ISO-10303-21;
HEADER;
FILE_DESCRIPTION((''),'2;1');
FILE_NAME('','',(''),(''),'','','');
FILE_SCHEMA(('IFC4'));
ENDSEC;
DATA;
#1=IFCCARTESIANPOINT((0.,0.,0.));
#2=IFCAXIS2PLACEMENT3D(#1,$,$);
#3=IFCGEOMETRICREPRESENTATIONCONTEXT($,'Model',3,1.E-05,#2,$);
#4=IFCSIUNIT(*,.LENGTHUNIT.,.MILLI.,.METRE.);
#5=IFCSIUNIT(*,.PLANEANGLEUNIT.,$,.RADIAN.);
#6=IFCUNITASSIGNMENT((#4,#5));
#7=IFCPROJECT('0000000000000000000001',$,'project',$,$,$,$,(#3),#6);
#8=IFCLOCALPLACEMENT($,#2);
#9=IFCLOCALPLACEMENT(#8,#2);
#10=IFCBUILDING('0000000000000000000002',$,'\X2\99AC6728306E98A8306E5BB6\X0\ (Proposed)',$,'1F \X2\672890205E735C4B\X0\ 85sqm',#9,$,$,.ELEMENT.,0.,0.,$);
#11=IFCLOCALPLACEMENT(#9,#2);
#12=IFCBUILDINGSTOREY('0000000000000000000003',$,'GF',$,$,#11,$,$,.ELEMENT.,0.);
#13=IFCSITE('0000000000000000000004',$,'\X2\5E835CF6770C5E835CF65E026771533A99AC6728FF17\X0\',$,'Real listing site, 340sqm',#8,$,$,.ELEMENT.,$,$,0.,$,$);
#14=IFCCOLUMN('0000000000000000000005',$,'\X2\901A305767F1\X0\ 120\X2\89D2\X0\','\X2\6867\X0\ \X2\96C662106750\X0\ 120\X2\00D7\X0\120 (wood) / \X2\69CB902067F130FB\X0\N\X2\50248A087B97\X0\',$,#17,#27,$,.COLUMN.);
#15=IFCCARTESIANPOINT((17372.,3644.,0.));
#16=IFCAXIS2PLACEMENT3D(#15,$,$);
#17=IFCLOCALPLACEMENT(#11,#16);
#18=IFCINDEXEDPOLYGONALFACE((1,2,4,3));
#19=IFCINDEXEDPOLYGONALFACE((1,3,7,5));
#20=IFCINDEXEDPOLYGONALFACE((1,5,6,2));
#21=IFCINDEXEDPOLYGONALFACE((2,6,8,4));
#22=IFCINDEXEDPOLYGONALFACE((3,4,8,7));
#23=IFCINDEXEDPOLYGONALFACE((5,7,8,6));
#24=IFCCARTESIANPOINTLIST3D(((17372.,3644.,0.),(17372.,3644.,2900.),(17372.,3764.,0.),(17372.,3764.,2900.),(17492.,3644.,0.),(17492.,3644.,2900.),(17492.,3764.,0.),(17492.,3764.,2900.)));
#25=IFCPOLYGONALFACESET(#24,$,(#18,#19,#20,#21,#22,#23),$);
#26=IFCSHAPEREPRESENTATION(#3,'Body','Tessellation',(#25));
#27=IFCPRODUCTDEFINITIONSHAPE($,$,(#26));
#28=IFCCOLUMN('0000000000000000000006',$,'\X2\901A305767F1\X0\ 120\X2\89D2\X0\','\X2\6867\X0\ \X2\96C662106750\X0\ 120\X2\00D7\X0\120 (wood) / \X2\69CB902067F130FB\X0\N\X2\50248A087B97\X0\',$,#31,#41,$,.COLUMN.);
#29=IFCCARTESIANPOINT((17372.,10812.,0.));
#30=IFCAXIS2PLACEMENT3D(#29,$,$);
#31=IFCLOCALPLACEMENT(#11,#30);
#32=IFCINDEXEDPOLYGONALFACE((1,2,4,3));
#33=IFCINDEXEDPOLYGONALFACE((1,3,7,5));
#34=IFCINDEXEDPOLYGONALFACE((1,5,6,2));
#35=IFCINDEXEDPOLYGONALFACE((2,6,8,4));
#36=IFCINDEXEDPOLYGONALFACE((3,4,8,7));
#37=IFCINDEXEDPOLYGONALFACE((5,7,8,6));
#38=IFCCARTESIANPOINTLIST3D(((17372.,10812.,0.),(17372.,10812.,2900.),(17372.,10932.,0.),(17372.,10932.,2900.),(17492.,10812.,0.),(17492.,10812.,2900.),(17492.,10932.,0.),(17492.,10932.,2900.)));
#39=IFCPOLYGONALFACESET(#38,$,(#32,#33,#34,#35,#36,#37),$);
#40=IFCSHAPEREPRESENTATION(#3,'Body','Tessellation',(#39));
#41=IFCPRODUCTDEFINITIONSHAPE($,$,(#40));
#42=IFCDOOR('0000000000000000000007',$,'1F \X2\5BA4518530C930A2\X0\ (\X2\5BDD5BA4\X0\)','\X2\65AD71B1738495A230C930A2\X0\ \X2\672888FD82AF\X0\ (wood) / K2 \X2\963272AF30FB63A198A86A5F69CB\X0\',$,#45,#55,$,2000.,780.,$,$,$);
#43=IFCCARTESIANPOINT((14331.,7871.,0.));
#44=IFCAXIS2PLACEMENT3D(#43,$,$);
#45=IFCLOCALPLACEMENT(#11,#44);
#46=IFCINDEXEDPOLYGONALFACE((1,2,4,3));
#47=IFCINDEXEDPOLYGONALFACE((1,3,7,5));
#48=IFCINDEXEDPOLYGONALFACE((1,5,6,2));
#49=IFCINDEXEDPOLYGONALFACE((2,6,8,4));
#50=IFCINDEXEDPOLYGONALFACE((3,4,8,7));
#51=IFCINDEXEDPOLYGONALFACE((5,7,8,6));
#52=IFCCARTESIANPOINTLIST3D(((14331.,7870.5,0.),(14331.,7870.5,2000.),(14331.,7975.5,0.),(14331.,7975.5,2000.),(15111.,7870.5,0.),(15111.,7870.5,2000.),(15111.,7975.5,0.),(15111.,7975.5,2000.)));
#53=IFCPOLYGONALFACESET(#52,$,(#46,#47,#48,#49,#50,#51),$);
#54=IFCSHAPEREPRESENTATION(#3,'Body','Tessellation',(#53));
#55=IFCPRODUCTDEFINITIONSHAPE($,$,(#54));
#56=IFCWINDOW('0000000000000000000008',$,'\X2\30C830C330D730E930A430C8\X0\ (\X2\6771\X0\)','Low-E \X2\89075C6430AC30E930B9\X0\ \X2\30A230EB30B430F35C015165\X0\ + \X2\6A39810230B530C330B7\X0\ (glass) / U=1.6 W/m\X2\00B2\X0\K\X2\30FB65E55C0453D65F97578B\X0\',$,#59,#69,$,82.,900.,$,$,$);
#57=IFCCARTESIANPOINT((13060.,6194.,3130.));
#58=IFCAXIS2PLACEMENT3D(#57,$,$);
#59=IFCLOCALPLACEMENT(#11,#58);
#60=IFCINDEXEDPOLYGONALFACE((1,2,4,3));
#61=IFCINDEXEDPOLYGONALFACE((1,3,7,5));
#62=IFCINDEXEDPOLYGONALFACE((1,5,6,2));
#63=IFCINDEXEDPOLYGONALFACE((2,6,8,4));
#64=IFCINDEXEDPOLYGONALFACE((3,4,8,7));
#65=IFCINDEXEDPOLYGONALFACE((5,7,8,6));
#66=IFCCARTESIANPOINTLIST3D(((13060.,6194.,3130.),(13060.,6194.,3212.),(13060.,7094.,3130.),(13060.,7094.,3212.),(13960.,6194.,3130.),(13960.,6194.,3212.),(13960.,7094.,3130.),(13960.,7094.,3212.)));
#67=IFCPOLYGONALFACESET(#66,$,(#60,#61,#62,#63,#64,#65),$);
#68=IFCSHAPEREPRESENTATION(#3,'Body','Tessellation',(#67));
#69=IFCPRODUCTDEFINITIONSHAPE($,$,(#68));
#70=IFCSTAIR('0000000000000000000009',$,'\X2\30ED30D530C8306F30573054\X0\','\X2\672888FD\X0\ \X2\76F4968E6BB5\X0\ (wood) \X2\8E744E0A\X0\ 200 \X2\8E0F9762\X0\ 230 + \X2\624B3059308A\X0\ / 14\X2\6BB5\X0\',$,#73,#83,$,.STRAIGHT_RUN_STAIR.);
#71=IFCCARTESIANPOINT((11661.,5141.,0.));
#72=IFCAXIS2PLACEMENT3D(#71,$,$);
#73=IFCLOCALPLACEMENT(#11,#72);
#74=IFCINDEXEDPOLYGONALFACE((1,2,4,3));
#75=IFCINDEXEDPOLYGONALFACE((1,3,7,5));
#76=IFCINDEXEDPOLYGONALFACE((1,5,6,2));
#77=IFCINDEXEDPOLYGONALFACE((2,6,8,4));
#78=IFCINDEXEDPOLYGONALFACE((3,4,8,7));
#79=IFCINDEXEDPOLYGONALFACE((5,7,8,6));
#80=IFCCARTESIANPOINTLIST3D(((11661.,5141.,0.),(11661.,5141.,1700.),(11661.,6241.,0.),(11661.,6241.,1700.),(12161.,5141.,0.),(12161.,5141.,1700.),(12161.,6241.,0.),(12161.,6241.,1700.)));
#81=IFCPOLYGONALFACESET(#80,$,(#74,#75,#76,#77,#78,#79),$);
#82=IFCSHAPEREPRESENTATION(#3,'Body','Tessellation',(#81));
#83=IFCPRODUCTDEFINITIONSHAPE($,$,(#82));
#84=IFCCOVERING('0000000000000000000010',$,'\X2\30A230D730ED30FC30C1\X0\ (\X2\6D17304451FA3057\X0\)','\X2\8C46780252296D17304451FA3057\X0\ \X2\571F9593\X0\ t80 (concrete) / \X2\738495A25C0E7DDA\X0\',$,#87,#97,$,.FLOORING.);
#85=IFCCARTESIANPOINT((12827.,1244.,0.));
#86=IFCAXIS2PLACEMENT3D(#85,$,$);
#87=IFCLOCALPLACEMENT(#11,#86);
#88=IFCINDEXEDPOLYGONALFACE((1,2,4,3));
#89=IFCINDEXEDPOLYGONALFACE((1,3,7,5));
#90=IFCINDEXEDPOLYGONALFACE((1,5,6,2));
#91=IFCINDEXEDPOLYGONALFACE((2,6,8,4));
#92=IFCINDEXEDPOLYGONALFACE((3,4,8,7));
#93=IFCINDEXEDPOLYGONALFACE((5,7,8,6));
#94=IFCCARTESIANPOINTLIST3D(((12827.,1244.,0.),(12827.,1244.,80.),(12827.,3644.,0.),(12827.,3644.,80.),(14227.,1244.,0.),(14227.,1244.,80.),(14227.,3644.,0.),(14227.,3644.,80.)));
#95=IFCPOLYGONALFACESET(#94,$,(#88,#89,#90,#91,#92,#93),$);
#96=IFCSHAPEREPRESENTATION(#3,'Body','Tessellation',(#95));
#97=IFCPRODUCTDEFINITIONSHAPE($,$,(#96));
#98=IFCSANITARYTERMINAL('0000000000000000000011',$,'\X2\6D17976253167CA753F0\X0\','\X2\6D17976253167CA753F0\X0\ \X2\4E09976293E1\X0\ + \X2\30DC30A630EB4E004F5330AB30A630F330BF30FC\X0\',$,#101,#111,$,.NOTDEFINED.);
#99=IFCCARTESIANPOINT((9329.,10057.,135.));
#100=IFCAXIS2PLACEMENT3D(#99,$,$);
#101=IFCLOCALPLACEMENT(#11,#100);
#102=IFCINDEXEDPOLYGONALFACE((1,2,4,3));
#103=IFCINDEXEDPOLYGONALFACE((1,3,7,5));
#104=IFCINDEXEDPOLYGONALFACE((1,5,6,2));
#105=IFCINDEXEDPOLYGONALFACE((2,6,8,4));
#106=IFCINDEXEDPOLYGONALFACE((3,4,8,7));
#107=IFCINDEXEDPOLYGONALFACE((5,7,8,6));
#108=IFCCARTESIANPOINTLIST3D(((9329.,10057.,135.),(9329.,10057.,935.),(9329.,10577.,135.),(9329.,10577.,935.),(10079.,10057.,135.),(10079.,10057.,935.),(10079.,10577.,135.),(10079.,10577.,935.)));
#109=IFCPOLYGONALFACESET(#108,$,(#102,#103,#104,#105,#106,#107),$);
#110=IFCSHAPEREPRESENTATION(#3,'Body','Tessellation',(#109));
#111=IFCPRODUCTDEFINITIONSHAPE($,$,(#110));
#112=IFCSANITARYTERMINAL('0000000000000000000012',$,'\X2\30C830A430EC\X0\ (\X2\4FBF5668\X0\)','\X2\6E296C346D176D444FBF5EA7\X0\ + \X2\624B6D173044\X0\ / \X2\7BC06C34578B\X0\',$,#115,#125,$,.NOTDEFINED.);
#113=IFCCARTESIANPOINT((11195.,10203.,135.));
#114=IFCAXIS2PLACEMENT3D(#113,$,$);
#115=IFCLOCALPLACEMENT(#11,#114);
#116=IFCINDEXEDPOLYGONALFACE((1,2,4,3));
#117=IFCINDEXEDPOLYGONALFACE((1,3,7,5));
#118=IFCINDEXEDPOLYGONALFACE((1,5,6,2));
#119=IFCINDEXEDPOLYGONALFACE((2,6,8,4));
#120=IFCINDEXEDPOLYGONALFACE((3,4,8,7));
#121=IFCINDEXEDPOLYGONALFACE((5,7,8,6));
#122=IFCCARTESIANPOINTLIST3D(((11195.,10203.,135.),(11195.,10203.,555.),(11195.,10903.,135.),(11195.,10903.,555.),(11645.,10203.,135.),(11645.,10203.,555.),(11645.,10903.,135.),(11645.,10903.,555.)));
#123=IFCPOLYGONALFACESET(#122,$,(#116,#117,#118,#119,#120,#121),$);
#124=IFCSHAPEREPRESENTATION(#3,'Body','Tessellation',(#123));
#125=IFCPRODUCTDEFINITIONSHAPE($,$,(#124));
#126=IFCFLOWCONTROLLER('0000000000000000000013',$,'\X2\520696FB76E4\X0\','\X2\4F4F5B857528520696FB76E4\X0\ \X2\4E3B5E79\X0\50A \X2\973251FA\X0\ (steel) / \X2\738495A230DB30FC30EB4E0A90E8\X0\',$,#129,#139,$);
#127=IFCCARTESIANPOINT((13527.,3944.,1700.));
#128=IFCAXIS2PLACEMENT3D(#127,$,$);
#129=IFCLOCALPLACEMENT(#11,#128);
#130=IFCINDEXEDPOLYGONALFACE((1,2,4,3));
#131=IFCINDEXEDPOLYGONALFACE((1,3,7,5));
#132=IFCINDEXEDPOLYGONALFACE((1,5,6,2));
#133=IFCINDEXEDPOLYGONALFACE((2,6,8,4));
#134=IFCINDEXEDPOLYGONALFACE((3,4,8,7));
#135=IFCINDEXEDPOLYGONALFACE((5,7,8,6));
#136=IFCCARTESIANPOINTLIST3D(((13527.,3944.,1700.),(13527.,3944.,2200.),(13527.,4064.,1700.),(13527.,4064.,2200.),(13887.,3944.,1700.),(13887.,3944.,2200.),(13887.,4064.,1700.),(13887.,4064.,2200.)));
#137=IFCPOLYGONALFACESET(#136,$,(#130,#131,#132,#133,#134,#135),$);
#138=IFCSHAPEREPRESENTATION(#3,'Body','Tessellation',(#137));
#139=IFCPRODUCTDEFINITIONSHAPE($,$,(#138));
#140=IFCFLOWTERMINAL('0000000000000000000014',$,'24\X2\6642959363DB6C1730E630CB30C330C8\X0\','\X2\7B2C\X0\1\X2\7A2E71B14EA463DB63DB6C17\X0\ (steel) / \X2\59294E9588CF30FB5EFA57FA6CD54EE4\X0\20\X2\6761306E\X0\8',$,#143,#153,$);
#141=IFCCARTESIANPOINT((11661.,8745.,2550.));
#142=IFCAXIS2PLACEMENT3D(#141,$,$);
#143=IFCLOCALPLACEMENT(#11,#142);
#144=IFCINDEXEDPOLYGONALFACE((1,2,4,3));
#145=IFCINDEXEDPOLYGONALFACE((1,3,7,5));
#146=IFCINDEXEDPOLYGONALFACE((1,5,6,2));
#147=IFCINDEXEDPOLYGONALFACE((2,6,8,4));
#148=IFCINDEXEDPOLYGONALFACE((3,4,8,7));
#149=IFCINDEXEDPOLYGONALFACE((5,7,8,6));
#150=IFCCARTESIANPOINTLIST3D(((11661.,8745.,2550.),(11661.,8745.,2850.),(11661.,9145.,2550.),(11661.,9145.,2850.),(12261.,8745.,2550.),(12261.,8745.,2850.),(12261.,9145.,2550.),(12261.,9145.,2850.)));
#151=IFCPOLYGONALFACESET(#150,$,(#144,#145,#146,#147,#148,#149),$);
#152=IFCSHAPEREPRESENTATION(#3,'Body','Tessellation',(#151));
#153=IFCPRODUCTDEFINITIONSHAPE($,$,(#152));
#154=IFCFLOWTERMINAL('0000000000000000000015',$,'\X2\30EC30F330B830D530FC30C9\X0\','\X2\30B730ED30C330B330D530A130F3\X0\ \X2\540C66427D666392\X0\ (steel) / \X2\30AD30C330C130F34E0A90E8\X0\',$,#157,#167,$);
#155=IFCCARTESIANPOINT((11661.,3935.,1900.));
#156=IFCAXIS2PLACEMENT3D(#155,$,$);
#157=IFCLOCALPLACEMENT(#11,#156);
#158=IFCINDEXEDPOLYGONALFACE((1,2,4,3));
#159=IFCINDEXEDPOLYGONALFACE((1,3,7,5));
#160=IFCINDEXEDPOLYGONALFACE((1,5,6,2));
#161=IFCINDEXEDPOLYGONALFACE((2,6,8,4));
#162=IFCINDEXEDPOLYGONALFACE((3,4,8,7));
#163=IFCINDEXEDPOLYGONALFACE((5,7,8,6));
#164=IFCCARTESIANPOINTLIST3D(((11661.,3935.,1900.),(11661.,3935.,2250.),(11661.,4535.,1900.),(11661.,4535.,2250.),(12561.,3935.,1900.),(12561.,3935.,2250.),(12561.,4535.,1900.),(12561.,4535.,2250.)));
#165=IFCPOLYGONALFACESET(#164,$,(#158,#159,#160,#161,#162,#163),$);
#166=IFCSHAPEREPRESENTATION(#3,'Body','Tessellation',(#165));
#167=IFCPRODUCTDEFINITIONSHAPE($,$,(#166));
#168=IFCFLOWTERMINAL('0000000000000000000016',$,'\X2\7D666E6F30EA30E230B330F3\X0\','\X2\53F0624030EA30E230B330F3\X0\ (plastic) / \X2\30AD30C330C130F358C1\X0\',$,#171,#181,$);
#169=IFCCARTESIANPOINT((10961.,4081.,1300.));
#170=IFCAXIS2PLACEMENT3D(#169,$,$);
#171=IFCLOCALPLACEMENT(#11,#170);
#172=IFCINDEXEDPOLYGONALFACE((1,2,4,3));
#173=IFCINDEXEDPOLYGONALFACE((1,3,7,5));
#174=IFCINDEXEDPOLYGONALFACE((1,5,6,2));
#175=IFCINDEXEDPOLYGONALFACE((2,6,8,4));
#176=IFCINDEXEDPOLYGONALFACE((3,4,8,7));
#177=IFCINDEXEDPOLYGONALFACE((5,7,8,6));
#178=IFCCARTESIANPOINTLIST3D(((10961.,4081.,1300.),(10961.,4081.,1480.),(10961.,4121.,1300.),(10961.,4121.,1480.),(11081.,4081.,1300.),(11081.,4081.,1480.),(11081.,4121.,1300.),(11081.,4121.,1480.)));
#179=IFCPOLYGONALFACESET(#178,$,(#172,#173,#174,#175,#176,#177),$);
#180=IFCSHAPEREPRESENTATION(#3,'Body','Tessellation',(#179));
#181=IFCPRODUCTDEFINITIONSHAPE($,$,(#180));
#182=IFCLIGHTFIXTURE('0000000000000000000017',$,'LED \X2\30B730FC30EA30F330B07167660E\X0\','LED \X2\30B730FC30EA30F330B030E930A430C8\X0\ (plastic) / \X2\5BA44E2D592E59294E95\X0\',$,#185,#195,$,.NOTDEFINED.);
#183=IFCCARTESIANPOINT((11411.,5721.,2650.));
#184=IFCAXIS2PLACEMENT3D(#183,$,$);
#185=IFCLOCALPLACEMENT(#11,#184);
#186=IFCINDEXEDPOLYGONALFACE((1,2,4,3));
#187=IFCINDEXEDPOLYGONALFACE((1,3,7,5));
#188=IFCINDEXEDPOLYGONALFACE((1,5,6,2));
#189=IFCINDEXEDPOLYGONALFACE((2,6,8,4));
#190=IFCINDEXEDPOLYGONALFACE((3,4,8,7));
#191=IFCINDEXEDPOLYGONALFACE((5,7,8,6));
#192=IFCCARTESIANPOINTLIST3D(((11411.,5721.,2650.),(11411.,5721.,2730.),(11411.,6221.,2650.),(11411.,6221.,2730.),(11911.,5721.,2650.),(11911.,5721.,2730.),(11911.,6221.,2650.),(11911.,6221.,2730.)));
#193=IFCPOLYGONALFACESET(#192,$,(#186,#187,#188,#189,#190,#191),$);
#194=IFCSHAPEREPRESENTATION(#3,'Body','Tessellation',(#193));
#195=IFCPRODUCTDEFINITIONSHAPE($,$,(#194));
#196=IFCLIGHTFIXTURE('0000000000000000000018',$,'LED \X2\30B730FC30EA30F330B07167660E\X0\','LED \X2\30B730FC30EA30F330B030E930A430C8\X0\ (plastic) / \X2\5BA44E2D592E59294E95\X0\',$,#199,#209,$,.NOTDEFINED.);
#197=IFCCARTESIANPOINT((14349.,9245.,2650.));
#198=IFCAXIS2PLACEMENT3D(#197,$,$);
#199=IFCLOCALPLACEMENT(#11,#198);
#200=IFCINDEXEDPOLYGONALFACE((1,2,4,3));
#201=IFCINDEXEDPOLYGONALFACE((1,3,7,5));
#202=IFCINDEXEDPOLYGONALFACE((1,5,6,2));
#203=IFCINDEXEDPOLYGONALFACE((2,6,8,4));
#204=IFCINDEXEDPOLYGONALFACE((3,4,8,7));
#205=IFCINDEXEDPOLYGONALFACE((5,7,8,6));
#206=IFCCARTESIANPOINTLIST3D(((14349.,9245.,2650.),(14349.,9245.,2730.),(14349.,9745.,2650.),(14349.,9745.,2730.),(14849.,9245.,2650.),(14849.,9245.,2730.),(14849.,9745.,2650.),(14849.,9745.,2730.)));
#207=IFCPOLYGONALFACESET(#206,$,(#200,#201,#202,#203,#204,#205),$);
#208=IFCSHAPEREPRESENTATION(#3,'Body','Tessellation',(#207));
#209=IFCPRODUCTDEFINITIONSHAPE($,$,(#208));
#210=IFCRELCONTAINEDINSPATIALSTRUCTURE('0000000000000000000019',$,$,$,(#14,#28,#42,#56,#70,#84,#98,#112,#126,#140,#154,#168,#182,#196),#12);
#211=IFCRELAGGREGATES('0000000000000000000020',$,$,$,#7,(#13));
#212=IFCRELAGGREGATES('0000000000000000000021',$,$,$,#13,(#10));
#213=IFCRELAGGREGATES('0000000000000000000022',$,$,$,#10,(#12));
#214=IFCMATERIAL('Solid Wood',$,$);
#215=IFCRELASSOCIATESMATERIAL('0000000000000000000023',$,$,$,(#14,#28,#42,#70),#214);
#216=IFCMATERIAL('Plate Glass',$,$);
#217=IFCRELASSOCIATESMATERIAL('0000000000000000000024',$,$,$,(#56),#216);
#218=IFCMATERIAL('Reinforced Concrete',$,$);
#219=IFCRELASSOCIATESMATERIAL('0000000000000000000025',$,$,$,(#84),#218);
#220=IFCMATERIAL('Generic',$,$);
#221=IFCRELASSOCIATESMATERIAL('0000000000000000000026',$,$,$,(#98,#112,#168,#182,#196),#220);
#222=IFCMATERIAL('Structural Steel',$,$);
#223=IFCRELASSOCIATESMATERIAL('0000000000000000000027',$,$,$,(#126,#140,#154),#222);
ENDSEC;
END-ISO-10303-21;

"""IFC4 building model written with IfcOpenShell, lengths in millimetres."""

from ifc_helpers import new_model, si_unit, frame, frame_2d, origin, place, context, project, spatial, rectangle, extrude, material, element, save


model = new_model("IFC4")

# Units and contexts
model_context = context("Model", 3, precision=1e-05, world=origin())
ifc_project = project(units=[si_unit("LENGTHUNIT", "METRE", prefix="MILLI"), si_unit("PLANEANGLEUNIT", "RADIAN")], contexts=[model_context])

# Site, building, storey
site_placement = place(None, origin())
site = spatial("IfcSite", under=ifc_project, at=site_placement, Name="広島県広島市東区馬木７", ObjectType="Real listing site, 340sqm", CompositionType="ELEMENT", RefElevation=0.0)
building_placement = place(site_placement, origin())
building = spatial("IfcBuilding", under=site, at=building_placement, Name="馬木の風の家 (Proposed)", ObjectType="1F 木造平屋 85sqm", CompositionType="ELEMENT", ElevationOfRefHeight=0.0, ElevationOfTerrain=0.0)
storey_placement = place(building_placement, origin())
storey = spatial("IfcBuildingStorey", under=building, at=storey_placement, Name="GF", CompositionType="ELEMENT", Elevation=0.0)

# Columns
ifc_material_1 = material(Name="Solid Wood")
column_1_placement = place(storey_placement, frame((17372.0, 3644.0, 0.0)))
element("IfcColumn", 1, at=column_1_placement, inside=storey, material=ifc_material_1, Name="通し柱 120角", Description="桧 集成材 120×120 (wood) / 構造柱・N値計算", PredefinedType="COLUMN", context=model_context, shape_type="SweptSolid", body=[
    extrude(rectangle(XDim=120.0, YDim=120.0, at=frame_2d((60.0, 60.0))), frame((17372.0, 3644.0, 0.0)), (0.0, 0.0, 1.0), 2900.0),
])
column_2_placement = place(storey_placement, frame((17372.0, 10812.0, 0.0)))
element("IfcColumn", 2, at=column_2_placement, inside=storey, material=ifc_material_1, Name="通し柱 120角", Description="桧 集成材 120×120 (wood) / 構造柱・N値計算", PredefinedType="COLUMN", context=model_context, shape_type="SweptSolid", body=[
    extrude(rectangle(XDim=120.0, YDim=120.0, at=frame_2d((60.0, 60.0))), frame((17372.0, 10812.0, 0.0)), (0.0, 0.0, 1.0), 2900.0),
])

# Shared definitions
ifc_material_2 = material(Name="Plate Glass")

# Door
door_placement = place(storey_placement, frame((14331.0, 7871.0, 0.0)))
element("IfcDoor", 3, at=door_placement, inside=storey, material=ifc_material_1, Name="1F 室内ドア (寝室)", Description="断熱玄関ドア 木製芯 (wood) / K2 防犯・採風機構", OverallHeight=2000.0, OverallWidth=780.0, context=model_context, shape_type="SweptSolid", body=[
    extrude(rectangle(XDim=780.0, YDim=105.0, at=frame_2d((390.0, 52.0))), frame((14331.0, 7871.0, 0.0)), (0.0, 0.0, 1.0), 2000.0),
])

# Window
window_1_placement = place(storey_placement, frame((13060.0, 6194.0, 3130.0)))
element("IfcWindow", 4, at=window_1_placement, inside=storey, material=ifc_material_2, Name="トップライト (東)", Description="Low-E 複層ガラス アルゴン封入 + 樹脂サッシ (glass) / U=1.6 W/m²K・日射取得型", OverallHeight=82.0, OverallWidth=900.0, context=model_context, shape_type="SweptSolid", body=[
    extrude(rectangle(XDim=900.0, YDim=900.0, at=frame_2d((450.0, 450.0))), frame((13060.0, 6194.0, 3130.0)), (0.0, 0.0, 1.0), 82.0),
])

# Stair
stair_placement = place(storey_placement, frame((11661.0, 5141.0, 0.0)))
element("IfcStair", 5, at=stair_placement, inside=storey, material=ifc_material_1, Name="ロフトはしご", Description="木製 直階段 (wood) 蹴上 200 踏面 230 + 手すり / 14段", PredefinedType="STRAIGHT_RUN_STAIR", context=model_context, shape_type="SweptSolid", body=[
    extrude(rectangle(XDim=500.0, YDim=1100.0, at=frame_2d((250.0, 550.0))), frame((11661.0, 5141.0, 0.0)), (0.0, 0.0, 1.0), 1700.0),
])

# Covering
ifc_material_3 = material(Name="Reinforced Concrete")
covering_placement = place(storey_placement, frame((12827.0, 1244.0, 0.0)))
element("IfcCovering", 6, at=covering_placement, inside=storey, material=ifc_material_3, Name="アプローチ (洗い出し)", Description="豆砂利洗い出し 土間 t80 (concrete) / 玄関導線", PredefinedType="FLOORING", context=model_context, shape_type="SweptSolid", body=[
    extrude(rectangle(XDim=1400.0, YDim=2400.0, at=frame_2d((700.0, 1200.0))), frame((12827.0, 1244.0, 0.0)), (0.0, 0.0, 1.0), 80.0),
])

# Sanitary terminals
ifc_material_4 = material(Name="Generic")
sanitary_terminal_1_placement = place(storey_placement, frame((9329.0, 10057.0, 135.0)))
element("IfcSanitaryTerminal", 7, at=sanitary_terminal_1_placement, inside=storey, material=ifc_material_4, Name="洗面化粧台", Description="洗面化粧台 三面鏡 + ボウル一体カウンター", PredefinedType="NOTDEFINED", context=model_context, shape_type="SweptSolid", body=[
    extrude(rectangle(XDim=750.0, YDim=520.0, at=frame_2d((375.0, 260.0))), frame((9329.0, 10057.0, 135.0)), (0.0, 0.0, 1.0), 800.0),
])
sanitary_terminal_2_placement = place(storey_placement, frame((11195.0, 10203.0, 135.0)))
element("IfcSanitaryTerminal", 8, at=sanitary_terminal_2_placement, inside=storey, material=ifc_material_4, Name="トイレ (便器)", Description="温水洗浄便座 + 手洗い / 節水型", PredefinedType="NOTDEFINED", context=model_context, shape_type="SweptSolid", body=[
    extrude(rectangle(XDim=450.0, YDim=700.0, at=frame_2d((225.0, 350.0))), frame((11195.0, 10203.0, 135.0)), (0.0, 0.0, 1.0), 420.0),
])

# Flow controller
ifc_material_5 = material(Name="Structural Steel")
flow_controller_placement = place(storey_placement, frame((13527.0, 3944.0, 1700.0)))
element("IfcFlowController", 9, at=flow_controller_placement, inside=storey, material=ifc_material_5, Name="分電盤", Description="住宅用分電盤 主幹50A 露出 (steel) / 玄関ホール上部", context=model_context, shape_type="SweptSolid", body=[
    extrude(rectangle(XDim=360.0, YDim=120.0, at=frame_2d((180.0, 60.0))), frame((13527.0, 3944.0, 1700.0)), (0.0, 0.0, 1.0), 500.0),
])

# Flow terminals
flow_terminal_1_placement = place(storey_placement, frame((11661.0, 8745.0, 2550.0)))
element("IfcFlowTerminal", 10, at=flow_terminal_1_placement, inside=storey, material=ifc_material_5, Name="24時間換気ユニット", Description="第1種熱交換換気 (steel) / 天井裏・建基法令20条の8", context=model_context, shape_type="SweptSolid", body=[
    extrude(rectangle(XDim=600.0, YDim=400.0, at=frame_2d((300.0, 200.0))), frame((11661.0, 8745.0, 2550.0)), (0.0, 0.0, 1.0), 300.0),
])
flow_terminal_2_placement = place(storey_placement, frame((11661.0, 3935.0, 1900.0)))
element("IfcFlowTerminal", 11, at=flow_terminal_2_placement, inside=storey, material=ifc_material_5, Name="レンジフード", Description="シロッコファン 同時給排 (steel) / キッチン上部", context=model_context, shape_type="SweptSolid", body=[
    extrude(rectangle(XDim=900.0, YDim=600.0, at=frame_2d((450.0, 300.0))), frame((11661.0, 3935.0, 1900.0)), (0.0, 0.0, 1.0), 350.0),
])
flow_terminal_3_placement = place(storey_placement, frame((10961.0, 4081.0, 1300.0)))
element("IfcFlowTerminal", 12, at=flow_terminal_3_placement, inside=storey, material=ifc_material_4, Name="給湯リモコン", Description="台所リモコン (plastic) / キッチン壁", context=model_context, shape_type="SweptSolid", body=[
    extrude(rectangle(XDim=120.0, YDim=40.0, at=frame_2d((60.0, 20.0))), frame((10961.0, 4081.0, 1300.0)), (0.0, 0.0, 1.0), 180.0),
])

# Light fixtures
light_fixture_1_placement = place(storey_placement, frame((11411.0, 5721.0, 2650.0)))
element("IfcLightFixture", 13, at=light_fixture_1_placement, inside=storey, material=ifc_material_4, Name="LED シーリング照明", Description="LED シーリングライト (plastic) / 室中央天井", PredefinedType="NOTDEFINED", context=model_context, shape_type="SweptSolid", body=[
    extrude(rectangle(XDim=500.0, YDim=500.0, at=frame_2d((250.0, 250.0))), frame((11411.0, 5721.0, 2650.0)), (0.0, 0.0, 1.0), 80.0),
])
light_fixture_2_placement = place(storey_placement, frame((14349.0, 9245.0, 2650.0)))
element("IfcLightFixture", 14, at=light_fixture_2_placement, inside=storey, material=ifc_material_4, Name="LED シーリング照明", Description="LED シーリングライト (plastic) / 室中央天井", PredefinedType="NOTDEFINED", context=model_context, shape_type="SweptSolid", body=[
    extrude(rectangle(XDim=500.0, YDim=500.0, at=frame_2d((250.0, 250.0))), frame((14349.0, 9245.0, 2650.0)), (0.0, 0.0, 1.0), 80.0),
])

save(model, "model.ifc")
